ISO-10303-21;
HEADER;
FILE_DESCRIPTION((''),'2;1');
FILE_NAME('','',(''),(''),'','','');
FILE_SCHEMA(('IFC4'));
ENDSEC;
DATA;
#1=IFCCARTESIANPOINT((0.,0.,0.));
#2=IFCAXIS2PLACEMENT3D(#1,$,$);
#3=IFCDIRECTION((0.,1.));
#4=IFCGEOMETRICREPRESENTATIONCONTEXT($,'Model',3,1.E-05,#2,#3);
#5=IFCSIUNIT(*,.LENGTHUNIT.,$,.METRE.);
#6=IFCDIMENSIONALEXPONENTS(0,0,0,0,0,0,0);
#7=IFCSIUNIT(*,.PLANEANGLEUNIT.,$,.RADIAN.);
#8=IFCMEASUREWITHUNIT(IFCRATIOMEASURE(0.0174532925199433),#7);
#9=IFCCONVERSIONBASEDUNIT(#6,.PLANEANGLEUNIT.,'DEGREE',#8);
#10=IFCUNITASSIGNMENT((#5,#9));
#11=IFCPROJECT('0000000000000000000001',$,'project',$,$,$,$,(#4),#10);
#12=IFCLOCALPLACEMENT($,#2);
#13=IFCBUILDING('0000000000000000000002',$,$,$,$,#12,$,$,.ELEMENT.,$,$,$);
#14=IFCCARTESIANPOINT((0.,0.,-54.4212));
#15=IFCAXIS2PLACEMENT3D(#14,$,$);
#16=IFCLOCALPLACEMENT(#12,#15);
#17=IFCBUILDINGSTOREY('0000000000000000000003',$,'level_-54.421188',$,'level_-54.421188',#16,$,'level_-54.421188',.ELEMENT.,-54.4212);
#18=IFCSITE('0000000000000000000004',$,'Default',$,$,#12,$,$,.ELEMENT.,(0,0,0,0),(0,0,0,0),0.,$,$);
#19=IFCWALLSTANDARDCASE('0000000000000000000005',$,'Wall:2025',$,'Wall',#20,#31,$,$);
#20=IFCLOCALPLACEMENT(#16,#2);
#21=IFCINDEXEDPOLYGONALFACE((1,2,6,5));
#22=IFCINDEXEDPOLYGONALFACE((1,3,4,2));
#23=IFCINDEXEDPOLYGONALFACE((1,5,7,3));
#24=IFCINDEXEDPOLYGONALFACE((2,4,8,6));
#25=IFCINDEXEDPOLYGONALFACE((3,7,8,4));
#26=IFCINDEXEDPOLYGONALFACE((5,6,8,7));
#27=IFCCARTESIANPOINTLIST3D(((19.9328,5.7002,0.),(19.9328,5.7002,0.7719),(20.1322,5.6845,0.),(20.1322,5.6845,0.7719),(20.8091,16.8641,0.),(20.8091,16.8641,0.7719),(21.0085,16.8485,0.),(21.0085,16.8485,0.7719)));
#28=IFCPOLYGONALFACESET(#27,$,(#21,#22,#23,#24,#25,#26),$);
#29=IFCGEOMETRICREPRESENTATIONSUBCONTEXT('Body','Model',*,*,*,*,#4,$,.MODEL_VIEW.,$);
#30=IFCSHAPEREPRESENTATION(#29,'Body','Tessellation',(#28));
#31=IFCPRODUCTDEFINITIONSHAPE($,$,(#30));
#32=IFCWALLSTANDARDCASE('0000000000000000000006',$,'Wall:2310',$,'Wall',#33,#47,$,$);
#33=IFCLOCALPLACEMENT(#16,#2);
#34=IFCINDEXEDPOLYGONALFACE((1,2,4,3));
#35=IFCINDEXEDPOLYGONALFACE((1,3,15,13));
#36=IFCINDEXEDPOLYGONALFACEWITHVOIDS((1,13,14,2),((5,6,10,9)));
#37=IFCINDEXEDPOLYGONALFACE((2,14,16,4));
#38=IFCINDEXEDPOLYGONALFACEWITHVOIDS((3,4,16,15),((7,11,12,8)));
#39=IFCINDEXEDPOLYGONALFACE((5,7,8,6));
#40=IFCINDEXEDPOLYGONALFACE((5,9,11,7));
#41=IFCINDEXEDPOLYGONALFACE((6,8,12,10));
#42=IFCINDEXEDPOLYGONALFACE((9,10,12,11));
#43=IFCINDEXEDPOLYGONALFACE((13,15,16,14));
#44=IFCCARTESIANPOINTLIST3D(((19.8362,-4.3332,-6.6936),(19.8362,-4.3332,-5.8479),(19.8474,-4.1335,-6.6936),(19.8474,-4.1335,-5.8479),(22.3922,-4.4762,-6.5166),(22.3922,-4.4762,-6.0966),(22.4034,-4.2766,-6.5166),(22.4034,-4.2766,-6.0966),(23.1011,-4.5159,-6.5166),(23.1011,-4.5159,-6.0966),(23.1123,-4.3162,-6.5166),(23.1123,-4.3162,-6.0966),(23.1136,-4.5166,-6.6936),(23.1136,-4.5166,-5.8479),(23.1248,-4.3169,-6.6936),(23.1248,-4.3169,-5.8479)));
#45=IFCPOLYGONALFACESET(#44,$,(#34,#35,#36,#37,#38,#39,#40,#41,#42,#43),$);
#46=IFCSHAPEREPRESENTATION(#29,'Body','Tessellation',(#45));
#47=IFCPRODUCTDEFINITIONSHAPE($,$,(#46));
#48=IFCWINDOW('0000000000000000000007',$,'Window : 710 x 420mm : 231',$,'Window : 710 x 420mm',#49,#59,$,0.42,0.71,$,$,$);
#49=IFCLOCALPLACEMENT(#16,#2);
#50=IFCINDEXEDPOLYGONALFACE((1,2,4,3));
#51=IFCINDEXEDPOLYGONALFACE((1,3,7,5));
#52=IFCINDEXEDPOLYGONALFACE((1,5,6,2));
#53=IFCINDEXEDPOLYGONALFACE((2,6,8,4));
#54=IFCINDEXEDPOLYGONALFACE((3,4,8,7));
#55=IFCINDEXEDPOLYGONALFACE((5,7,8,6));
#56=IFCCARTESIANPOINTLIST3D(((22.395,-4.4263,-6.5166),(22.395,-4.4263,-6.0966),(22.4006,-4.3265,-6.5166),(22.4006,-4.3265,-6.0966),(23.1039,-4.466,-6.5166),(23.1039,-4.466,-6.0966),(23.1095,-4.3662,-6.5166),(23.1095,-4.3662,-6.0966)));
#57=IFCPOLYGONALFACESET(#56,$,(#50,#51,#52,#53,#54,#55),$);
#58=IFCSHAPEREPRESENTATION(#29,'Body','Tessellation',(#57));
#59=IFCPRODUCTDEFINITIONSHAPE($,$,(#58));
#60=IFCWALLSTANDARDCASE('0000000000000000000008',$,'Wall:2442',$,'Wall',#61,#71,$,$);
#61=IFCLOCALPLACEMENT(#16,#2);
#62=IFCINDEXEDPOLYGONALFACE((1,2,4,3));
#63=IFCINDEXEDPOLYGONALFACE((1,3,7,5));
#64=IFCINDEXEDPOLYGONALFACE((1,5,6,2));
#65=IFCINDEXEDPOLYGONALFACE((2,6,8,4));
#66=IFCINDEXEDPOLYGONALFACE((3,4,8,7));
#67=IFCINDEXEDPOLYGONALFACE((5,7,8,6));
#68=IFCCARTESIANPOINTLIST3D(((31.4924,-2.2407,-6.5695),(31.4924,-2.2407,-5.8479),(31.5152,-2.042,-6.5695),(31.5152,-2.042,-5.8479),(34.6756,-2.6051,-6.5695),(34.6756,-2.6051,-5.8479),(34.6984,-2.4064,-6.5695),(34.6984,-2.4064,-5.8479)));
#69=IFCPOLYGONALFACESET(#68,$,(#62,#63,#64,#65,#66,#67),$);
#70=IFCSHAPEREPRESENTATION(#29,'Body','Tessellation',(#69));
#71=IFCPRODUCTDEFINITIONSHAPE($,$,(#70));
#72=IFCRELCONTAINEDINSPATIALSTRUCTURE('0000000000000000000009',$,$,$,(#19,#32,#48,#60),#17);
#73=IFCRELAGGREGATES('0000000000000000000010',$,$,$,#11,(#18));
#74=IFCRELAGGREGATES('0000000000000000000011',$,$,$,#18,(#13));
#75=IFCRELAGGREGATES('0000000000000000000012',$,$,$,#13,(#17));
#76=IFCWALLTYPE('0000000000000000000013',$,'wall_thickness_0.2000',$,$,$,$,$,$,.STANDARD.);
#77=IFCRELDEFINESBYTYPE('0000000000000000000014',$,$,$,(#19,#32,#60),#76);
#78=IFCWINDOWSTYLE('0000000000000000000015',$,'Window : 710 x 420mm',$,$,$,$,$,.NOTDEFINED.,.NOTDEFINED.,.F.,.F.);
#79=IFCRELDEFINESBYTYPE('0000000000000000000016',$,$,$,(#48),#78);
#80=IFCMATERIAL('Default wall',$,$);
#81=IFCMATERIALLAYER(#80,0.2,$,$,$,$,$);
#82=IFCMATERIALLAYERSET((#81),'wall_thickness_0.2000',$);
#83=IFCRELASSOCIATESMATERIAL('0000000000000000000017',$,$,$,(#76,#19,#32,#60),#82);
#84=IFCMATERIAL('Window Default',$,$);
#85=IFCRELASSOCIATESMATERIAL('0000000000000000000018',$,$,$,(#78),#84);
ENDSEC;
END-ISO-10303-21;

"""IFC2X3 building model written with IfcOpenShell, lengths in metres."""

from ifc_helpers import new_model, entity, si_unit, converted_unit, direction, frame, frame_2d, origin, origin_2d_with_axis, place, context, subcontext, project, spatial, polyline, rectangle, outline, extrude, source, transform, mapped, material, layer, layer_set, layer_usage, type_object, type_shapes, element, fill, save


model = new_model("IFC2X3")

# Units and contexts
model_context = context("Model", 3, precision=1e-05, world=origin(), true_north=direction((0.0, 1.0)))
body_context = subcontext(model_context, "Body", "Model", "MODEL_VIEW")
ifc_project = project(units=[si_unit("LENGTHUNIT", "METRE"), converted_unit("PLANEANGLEUNIT", "DEGREE", entity("IfcRatioMeasure", 0.0174532925199433), si_unit("PLANEANGLEUNIT", "RADIAN"), dimensions=[0, 0, 0, 0, 0, 0, 0])], contexts=[model_context])

# Site, building, storey
placement_1 = place(None, origin())
site = spatial("IfcSite", under=ifc_project, at=placement_1, Name="Default", CompositionType="ELEMENT", RefLatitude=(0, 0, 0, 0), RefLongitude=(0, 0, 0, 0), RefElevation=0.0)
building = spatial("IfcBuilding", under=site, at=placement_1, CompositionType="ELEMENT")
storey_placement = place(placement_1, frame((0.0, 0.0, -54.4212)))
storey = spatial("IfcBuildingStorey", under=building, at=storey_placement, Name="level_-54.421188", ObjectType="level_-54.421188", LongName="level_-54.421188", CompositionType="ELEMENT", Elevation=-54.4212)

# Shared definitions
ifc_material_1 = material(Name="Default wall")
ifc_layer = layer(ifc_material_1, 0.2)
ifc_layer_set = layer_set([ifc_layer], Name="wall_thickness_0.2000")
ifc_layer_usage = layer_usage(ifc_layer_set, "AXIS2", "POSITIVE", -0.1)
wall_type = type_object("IfcWallType", Name="wall_thickness_0.2000", PredefinedType="STANDARD", material=ifc_layer_set)
ifc_material_2 = material(Name="Window Default")

# Wall
wall_1_placement = place(storey_placement, frame((20.0325, 5.6924, 0.0), z_axis=(0.0, 0.0, 1.0), x_axis=(0.078247, 0.996934, 0.0)))
element("IfcWallStandardCase", 1, at=wall_1_placement, inside=storey, type_object=wall_type, material=ifc_layer_usage, Name="Wall:2025", ObjectType="Wall", context=body_context, shape_type="SweptSolid", body=[
    extrude(outline(polyline([(11.1983, -0.1), (11.1983, 0.1), (0.0, 0.1), (0.0, -0.1), (11.1983, -0.1)])), origin(), (0.0, 0.0, 1.0), 0.7719),
])

# Wall, opening, window
placement_2 = place(placement_1, frame((0.0, 0.0, -61.1148)))
wall_2_placement = place(placement_2, frame((19.8418, -4.2333, 0.0), z_axis=(0.0, 0.0, 1.0), x_axis=(0.998437, -0.055889, 0.0)))
wall_2 = element("IfcWallStandardCase", 2, at=wall_2_placement, inside=storey, type_object=wall_type, material=ifc_layer_usage, Name="Wall:2310", ObjectType="Wall", context=body_context, shape_type="SweptSolid", body=[
    extrude(outline(polyline([(3.2825, -0.1), (3.2825, 0.1), (0.0, 0.1), (0.0, -0.1), (3.2825, -0.1)])), origin(), (0.0, 0.0, 1.0), 0.8457),
])
opening_1_placement = place(wall_2_placement, frame((2.56, -0.1, 0.177)))
opening_1 = element("IfcOpeningElement", 3, at=opening_1_placement, cuts=wall_2, ObjectType="Opening", context=body_context, shape_type="SweptSolid", body=[
    extrude(rectangle(XDim=0.71, YDim=0.42, at=frame_2d((0.21, 0.355), x_axis=(0.0, 1.0))), frame((0.0, 0.0, 0.0), z_axis=(0.0, 1.0, 0.0), x_axis=(0.0, 0.0, 1.0)), (0.0, 0.0, 1.0), 0.2),
])
window_style_1 = type_object("IfcWindowStyle", Name="Window : 710 x 420mm", ConstructionType="NOTDEFINED", OperationType="NOTDEFINED", ParameterTakesPrecedence=False, Sizeable=False, material=ifc_material_2)
shared_shape_1 = source(origin(), body_context, "Body", "SweptSolid", [
    extrude(rectangle(XDim=0.1, YDim=0.71, at=origin_2d_with_axis()), frame((0.355, 0.1, 0.0), z_axis=(0.0, 0.0, 1.0), x_axis=(0.0, 1.0, 0.0)), (0.0, 0.0, 1.0), 0.42),
])
type_shapes(window_style_1, [shared_shape_1])
window_1_placement = place(opening_1_placement, origin())
window_1 = element("IfcWindow", 4, at=window_1_placement, inside=storey, type_object=window_style_1, Name="Window : 710 x 420mm : 231", ObjectType="Window : 710 x 420mm", OverallHeight=0.42, OverallWidth=0.71, context=body_context, shape_type="MappedRepresentation", body=[
    mapped(shared_shape_1, transform((0.0, 0.0, 0.0), scale=1.0)),
])
fill(opening_1, window_1)

# Wall
placement_3 = place(placement_1, frame((0.0, 0.0, -60.9907)))
wall_3_placement = place(placement_3, frame((31.5038, -2.1414, 0.0), z_axis=(0.0, 0.0, 1.0), x_axis=(0.993513, -0.113717, 0.0)))
element("IfcWallStandardCase", 5, at=wall_3_placement, inside=storey, type_object=wall_type, material=ifc_layer_usage, Name="Wall:2442", ObjectType="Wall", context=body_context, shape_type="SweptSolid", body=[
    extrude(outline(polyline([(3.204, -0.1), (3.204, 0.1), (0.0, 0.1), (0.0, -0.1), (3.204, -0.1)])), origin(), (0.0, 0.0, 1.0), 0.7215),
])

save(model, "model.ifc")
